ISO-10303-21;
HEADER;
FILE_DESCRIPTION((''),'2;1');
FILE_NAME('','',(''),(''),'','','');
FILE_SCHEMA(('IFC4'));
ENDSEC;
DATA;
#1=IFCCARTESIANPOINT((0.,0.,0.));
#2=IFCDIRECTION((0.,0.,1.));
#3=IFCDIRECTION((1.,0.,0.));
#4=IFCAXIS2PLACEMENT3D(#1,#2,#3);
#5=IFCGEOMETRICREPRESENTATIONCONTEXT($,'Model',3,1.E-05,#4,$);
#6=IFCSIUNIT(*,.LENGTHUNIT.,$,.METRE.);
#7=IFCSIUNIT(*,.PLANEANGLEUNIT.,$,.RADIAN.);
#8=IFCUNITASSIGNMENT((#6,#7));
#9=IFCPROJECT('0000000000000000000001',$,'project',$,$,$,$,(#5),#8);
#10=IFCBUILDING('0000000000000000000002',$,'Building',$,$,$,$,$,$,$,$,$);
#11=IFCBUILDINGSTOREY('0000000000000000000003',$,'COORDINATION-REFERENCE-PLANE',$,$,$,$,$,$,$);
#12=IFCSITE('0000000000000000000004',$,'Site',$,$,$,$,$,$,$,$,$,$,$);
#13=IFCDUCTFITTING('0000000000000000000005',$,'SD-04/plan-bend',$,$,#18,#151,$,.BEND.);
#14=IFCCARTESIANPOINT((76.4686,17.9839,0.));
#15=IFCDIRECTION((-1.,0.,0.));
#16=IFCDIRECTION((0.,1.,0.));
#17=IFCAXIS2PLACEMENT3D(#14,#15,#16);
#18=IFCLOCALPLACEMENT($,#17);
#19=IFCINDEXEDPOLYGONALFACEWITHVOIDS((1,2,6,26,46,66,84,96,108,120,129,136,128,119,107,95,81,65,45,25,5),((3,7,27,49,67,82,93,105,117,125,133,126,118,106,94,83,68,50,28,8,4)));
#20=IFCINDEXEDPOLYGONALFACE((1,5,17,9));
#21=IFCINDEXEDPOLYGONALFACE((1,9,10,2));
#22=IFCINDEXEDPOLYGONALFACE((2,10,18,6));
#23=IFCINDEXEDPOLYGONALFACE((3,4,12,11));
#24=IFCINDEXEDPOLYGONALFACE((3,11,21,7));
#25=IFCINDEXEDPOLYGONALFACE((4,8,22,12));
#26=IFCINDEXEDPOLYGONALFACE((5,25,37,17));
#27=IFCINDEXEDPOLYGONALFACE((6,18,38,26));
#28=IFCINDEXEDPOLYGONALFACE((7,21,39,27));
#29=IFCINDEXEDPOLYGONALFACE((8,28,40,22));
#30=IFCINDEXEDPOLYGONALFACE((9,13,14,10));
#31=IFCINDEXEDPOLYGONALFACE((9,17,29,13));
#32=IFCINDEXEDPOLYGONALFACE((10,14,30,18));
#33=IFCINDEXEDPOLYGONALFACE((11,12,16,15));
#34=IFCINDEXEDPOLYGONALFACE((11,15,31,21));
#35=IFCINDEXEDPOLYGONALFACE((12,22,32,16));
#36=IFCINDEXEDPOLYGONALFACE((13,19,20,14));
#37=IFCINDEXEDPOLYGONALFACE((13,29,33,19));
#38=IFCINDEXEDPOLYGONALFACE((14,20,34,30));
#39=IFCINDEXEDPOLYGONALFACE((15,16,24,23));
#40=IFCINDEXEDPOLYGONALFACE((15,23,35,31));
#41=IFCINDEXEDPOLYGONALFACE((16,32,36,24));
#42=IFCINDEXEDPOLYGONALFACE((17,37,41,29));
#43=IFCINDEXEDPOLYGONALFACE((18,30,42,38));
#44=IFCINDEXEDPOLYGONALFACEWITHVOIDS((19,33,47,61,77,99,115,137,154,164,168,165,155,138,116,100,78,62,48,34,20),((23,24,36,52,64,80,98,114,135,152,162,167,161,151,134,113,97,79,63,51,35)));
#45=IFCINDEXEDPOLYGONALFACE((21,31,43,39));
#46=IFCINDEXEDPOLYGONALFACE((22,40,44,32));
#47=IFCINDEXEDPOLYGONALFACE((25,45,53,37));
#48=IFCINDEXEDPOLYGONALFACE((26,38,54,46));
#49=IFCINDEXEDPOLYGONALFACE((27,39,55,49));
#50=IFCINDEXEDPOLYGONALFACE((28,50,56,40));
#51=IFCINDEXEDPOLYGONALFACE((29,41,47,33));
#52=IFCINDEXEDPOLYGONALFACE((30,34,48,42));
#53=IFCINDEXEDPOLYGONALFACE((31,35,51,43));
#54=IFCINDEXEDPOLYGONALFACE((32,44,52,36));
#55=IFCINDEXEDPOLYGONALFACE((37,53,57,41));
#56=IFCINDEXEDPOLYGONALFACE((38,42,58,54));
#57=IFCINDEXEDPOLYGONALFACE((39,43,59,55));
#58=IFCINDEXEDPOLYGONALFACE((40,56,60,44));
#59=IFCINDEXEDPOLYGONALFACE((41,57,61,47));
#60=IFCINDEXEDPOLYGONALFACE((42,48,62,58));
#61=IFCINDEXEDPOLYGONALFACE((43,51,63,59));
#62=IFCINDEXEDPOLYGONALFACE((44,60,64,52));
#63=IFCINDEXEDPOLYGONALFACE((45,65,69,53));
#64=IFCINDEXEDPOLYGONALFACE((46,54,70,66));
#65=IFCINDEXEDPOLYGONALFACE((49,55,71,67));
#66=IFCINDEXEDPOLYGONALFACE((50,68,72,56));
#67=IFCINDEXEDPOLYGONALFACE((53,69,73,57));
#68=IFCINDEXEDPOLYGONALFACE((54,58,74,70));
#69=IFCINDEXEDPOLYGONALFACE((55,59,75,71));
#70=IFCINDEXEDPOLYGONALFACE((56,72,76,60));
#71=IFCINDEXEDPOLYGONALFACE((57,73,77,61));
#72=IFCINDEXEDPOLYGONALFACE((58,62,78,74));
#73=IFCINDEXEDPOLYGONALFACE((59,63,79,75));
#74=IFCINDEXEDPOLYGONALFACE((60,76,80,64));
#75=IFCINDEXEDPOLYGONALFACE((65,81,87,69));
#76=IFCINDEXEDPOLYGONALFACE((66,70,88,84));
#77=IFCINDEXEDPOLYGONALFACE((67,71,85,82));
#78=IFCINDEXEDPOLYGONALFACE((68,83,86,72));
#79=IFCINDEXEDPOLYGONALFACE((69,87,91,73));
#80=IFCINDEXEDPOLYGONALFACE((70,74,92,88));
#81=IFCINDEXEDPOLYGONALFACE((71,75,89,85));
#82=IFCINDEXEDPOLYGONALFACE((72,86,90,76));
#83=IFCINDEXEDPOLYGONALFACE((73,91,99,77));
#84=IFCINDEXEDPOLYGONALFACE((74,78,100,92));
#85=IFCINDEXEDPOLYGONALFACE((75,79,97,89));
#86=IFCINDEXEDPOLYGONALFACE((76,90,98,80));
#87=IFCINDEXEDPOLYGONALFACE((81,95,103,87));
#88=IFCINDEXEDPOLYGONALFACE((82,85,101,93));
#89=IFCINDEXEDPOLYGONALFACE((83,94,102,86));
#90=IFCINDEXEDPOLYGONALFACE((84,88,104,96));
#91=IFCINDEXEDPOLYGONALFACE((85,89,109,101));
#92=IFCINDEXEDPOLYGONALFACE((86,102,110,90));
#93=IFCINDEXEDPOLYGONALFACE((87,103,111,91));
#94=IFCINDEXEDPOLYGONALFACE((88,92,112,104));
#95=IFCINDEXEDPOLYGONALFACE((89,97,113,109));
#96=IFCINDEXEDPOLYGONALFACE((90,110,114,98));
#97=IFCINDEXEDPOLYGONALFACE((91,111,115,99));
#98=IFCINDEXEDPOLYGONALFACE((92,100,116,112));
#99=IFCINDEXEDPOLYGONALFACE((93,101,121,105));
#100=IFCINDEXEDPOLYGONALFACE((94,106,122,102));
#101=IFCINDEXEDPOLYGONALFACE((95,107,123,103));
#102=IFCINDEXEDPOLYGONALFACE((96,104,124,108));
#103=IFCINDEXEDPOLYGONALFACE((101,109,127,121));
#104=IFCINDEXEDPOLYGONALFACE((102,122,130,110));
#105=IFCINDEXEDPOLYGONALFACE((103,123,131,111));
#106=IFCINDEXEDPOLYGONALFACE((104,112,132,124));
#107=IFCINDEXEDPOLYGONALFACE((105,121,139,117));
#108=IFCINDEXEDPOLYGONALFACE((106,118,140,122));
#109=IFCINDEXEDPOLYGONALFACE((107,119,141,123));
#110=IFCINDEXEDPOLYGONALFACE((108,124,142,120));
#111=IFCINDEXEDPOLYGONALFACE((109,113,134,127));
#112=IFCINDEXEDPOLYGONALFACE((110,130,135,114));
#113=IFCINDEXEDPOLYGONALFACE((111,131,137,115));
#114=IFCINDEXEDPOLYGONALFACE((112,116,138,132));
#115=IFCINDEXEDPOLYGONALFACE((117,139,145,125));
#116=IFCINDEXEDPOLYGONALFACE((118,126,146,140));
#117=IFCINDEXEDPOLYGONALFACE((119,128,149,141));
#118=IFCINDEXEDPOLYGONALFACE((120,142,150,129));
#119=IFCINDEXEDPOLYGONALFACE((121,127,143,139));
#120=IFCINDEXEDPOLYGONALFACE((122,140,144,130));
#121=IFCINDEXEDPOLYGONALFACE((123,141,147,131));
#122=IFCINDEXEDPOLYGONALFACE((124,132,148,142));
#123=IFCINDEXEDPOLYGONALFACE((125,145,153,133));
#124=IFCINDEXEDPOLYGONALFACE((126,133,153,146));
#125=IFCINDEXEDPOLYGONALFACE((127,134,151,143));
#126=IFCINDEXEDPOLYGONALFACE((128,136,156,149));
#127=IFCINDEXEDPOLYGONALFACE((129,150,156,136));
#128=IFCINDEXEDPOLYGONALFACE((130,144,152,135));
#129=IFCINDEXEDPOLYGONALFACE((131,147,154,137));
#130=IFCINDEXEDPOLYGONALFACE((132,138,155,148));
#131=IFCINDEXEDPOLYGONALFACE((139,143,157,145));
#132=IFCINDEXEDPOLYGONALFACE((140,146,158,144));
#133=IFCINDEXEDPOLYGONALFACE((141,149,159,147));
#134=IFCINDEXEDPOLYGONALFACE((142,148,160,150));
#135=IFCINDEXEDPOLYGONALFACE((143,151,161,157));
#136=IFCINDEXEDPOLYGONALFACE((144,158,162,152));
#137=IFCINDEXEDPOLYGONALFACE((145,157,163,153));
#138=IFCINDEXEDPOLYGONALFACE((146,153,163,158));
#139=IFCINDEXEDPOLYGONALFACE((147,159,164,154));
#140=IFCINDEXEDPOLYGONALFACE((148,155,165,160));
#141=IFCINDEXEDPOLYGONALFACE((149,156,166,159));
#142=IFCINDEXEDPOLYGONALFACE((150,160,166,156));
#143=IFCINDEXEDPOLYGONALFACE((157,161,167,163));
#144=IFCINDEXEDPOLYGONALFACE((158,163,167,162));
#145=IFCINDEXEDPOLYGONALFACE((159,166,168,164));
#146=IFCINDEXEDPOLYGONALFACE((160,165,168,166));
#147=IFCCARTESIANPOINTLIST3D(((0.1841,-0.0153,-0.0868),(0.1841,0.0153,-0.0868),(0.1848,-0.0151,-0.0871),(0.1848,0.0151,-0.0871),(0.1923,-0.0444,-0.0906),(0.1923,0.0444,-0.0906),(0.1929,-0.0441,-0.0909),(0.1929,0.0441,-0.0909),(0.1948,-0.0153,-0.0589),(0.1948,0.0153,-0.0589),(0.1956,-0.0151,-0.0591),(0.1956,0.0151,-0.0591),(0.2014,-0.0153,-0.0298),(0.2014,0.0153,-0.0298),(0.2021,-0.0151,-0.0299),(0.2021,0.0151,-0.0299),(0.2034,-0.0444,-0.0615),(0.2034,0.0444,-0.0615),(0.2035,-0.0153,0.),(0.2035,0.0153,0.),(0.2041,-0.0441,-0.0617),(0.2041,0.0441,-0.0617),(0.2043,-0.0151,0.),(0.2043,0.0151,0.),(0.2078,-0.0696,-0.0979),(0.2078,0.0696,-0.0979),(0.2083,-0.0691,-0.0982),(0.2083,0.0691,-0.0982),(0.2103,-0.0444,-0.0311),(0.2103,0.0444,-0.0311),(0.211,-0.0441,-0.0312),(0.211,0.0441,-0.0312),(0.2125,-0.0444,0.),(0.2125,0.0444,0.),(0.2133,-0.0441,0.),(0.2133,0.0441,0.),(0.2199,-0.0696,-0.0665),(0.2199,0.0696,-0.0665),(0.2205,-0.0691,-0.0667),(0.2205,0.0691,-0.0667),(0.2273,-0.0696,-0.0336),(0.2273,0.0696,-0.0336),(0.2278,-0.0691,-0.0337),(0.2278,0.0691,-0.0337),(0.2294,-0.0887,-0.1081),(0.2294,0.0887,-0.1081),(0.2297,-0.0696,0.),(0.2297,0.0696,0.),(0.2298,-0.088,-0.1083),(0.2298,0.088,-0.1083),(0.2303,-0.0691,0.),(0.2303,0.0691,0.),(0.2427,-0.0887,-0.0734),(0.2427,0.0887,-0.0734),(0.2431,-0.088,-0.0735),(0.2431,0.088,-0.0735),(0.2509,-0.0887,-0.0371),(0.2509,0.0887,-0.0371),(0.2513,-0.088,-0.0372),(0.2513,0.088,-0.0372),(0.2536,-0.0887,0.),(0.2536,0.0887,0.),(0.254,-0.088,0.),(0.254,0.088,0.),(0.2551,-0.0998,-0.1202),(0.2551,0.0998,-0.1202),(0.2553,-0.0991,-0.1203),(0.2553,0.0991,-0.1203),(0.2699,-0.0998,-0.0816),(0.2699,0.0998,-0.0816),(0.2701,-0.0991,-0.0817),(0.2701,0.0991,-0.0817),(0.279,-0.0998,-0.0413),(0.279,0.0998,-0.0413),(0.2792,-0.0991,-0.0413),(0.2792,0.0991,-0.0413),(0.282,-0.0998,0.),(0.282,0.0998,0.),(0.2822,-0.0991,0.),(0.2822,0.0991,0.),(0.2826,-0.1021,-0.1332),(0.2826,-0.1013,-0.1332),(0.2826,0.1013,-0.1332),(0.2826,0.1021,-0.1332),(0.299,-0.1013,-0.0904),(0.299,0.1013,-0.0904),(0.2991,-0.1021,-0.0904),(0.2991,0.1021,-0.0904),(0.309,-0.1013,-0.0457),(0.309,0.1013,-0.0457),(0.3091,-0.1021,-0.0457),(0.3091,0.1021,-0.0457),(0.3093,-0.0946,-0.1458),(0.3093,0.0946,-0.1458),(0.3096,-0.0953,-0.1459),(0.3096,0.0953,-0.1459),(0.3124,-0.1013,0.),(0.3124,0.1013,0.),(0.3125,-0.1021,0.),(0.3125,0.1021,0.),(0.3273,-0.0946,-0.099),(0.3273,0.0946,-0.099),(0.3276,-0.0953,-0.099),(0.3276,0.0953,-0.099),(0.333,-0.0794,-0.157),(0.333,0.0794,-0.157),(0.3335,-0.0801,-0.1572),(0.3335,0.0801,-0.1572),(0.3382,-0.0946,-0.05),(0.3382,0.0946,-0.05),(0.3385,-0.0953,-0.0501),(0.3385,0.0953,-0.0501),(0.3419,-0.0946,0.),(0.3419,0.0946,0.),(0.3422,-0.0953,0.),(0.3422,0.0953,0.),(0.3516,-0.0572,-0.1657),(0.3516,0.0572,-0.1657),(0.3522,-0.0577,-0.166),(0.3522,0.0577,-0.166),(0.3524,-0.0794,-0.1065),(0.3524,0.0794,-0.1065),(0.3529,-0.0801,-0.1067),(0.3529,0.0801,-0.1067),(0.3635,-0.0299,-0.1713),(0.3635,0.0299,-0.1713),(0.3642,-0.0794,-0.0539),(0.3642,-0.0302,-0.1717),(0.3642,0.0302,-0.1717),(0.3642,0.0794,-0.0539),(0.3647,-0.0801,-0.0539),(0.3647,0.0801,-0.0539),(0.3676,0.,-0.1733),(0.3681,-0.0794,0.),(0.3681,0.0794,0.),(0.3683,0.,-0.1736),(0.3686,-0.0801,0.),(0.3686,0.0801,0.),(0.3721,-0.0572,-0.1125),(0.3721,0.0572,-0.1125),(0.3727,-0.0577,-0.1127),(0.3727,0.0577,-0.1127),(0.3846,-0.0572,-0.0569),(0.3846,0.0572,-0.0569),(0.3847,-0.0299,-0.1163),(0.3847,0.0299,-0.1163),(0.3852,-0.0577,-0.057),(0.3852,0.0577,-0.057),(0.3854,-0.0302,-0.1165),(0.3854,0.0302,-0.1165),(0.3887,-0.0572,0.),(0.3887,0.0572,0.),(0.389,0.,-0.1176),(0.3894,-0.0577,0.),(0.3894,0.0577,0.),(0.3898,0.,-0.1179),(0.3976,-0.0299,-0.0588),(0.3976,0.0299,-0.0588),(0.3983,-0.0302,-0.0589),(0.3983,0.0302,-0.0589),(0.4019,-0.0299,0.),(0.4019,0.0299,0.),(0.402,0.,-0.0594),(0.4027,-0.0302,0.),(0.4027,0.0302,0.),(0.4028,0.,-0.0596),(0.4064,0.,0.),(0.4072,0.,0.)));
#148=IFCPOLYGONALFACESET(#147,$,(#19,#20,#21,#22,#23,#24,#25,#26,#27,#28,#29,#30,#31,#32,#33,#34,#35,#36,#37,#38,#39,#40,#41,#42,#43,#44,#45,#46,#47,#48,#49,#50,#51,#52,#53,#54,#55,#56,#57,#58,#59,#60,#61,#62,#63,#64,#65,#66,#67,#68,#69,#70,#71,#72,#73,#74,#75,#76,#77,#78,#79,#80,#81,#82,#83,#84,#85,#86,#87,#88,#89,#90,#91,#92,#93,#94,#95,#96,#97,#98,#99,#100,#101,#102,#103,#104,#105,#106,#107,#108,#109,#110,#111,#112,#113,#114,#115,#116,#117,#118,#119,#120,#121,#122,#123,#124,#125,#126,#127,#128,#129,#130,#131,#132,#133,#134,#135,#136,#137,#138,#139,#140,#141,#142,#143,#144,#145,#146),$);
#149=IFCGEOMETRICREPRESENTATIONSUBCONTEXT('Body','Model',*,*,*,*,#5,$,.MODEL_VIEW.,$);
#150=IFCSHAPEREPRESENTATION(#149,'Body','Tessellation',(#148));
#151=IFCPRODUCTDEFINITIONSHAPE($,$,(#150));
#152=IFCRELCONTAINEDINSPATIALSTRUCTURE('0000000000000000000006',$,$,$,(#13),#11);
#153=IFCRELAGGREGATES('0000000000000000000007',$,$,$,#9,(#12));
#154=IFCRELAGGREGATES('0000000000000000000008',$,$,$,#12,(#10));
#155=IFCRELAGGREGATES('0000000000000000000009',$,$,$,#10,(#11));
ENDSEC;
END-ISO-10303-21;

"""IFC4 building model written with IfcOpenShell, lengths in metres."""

from ifc_helpers import new_model, entity, si_unit, frame, origin_with_axes, place, context, subcontext, project, spatial, element, save


model = new_model("IFC4")

# Units and contexts
model_context_1 = context("Model", 3, precision=1e-05, world=origin_with_axes())
body_context_1 = subcontext(model_context_1, "Body", "Model", "MODEL_VIEW")
ifc_project = project(units=[si_unit("LENGTHUNIT", "METRE"), si_unit("PLANEANGLEUNIT", "RADIAN")], contexts=[model_context_1])

# Site, building, storey
site = spatial("IfcSite", under=ifc_project, Name="Site")
building = spatial("IfcBuilding", under=site, Name="Building")
storey = spatial("IfcBuildingStorey", under=building, Name="COORDINATION-REFERENCE-PLANE")

# Duct fitting
duct_fitting_1_placement = place(None, frame((76.4686, 17.9839, 0.0), z_axis=(-1.0, 0.0, 0.0), x_axis=(0.0, 1.0, 0.0)))
element("IfcDuctFitting", 1, at=duct_fitting_1_placement, inside=storey, Name="SD-04/plan-bend", PredefinedType="BEND", context=body_context_1, shape_type="SweptSolid", body=[
    entity("IfcRevolvedAreaSolid", entity("IfcCircleHollowProfileDef", "AREA", None, entity("IfcAxis2Placement2D", entity("IfcCartesianPoint", [0.3048, 0.0])), 0.1024, 0.0008), entity("IfcAxis2Placement3D", entity("IfcCartesianPoint", [0.0, 0.0, 0.0]), entity("IfcDirection", [0.0, 0.0, 1.0]), entity("IfcDirection", [1.0, 0.0, 0.0])), entity("IfcAxis1Placement", entity("IfcCartesianPoint", [0.0, 0.0, 0.0]), entity("IfcDirection", [0.0, 1.0, 0.0])), 0.440428),
])

save(model, "model.ifc")
